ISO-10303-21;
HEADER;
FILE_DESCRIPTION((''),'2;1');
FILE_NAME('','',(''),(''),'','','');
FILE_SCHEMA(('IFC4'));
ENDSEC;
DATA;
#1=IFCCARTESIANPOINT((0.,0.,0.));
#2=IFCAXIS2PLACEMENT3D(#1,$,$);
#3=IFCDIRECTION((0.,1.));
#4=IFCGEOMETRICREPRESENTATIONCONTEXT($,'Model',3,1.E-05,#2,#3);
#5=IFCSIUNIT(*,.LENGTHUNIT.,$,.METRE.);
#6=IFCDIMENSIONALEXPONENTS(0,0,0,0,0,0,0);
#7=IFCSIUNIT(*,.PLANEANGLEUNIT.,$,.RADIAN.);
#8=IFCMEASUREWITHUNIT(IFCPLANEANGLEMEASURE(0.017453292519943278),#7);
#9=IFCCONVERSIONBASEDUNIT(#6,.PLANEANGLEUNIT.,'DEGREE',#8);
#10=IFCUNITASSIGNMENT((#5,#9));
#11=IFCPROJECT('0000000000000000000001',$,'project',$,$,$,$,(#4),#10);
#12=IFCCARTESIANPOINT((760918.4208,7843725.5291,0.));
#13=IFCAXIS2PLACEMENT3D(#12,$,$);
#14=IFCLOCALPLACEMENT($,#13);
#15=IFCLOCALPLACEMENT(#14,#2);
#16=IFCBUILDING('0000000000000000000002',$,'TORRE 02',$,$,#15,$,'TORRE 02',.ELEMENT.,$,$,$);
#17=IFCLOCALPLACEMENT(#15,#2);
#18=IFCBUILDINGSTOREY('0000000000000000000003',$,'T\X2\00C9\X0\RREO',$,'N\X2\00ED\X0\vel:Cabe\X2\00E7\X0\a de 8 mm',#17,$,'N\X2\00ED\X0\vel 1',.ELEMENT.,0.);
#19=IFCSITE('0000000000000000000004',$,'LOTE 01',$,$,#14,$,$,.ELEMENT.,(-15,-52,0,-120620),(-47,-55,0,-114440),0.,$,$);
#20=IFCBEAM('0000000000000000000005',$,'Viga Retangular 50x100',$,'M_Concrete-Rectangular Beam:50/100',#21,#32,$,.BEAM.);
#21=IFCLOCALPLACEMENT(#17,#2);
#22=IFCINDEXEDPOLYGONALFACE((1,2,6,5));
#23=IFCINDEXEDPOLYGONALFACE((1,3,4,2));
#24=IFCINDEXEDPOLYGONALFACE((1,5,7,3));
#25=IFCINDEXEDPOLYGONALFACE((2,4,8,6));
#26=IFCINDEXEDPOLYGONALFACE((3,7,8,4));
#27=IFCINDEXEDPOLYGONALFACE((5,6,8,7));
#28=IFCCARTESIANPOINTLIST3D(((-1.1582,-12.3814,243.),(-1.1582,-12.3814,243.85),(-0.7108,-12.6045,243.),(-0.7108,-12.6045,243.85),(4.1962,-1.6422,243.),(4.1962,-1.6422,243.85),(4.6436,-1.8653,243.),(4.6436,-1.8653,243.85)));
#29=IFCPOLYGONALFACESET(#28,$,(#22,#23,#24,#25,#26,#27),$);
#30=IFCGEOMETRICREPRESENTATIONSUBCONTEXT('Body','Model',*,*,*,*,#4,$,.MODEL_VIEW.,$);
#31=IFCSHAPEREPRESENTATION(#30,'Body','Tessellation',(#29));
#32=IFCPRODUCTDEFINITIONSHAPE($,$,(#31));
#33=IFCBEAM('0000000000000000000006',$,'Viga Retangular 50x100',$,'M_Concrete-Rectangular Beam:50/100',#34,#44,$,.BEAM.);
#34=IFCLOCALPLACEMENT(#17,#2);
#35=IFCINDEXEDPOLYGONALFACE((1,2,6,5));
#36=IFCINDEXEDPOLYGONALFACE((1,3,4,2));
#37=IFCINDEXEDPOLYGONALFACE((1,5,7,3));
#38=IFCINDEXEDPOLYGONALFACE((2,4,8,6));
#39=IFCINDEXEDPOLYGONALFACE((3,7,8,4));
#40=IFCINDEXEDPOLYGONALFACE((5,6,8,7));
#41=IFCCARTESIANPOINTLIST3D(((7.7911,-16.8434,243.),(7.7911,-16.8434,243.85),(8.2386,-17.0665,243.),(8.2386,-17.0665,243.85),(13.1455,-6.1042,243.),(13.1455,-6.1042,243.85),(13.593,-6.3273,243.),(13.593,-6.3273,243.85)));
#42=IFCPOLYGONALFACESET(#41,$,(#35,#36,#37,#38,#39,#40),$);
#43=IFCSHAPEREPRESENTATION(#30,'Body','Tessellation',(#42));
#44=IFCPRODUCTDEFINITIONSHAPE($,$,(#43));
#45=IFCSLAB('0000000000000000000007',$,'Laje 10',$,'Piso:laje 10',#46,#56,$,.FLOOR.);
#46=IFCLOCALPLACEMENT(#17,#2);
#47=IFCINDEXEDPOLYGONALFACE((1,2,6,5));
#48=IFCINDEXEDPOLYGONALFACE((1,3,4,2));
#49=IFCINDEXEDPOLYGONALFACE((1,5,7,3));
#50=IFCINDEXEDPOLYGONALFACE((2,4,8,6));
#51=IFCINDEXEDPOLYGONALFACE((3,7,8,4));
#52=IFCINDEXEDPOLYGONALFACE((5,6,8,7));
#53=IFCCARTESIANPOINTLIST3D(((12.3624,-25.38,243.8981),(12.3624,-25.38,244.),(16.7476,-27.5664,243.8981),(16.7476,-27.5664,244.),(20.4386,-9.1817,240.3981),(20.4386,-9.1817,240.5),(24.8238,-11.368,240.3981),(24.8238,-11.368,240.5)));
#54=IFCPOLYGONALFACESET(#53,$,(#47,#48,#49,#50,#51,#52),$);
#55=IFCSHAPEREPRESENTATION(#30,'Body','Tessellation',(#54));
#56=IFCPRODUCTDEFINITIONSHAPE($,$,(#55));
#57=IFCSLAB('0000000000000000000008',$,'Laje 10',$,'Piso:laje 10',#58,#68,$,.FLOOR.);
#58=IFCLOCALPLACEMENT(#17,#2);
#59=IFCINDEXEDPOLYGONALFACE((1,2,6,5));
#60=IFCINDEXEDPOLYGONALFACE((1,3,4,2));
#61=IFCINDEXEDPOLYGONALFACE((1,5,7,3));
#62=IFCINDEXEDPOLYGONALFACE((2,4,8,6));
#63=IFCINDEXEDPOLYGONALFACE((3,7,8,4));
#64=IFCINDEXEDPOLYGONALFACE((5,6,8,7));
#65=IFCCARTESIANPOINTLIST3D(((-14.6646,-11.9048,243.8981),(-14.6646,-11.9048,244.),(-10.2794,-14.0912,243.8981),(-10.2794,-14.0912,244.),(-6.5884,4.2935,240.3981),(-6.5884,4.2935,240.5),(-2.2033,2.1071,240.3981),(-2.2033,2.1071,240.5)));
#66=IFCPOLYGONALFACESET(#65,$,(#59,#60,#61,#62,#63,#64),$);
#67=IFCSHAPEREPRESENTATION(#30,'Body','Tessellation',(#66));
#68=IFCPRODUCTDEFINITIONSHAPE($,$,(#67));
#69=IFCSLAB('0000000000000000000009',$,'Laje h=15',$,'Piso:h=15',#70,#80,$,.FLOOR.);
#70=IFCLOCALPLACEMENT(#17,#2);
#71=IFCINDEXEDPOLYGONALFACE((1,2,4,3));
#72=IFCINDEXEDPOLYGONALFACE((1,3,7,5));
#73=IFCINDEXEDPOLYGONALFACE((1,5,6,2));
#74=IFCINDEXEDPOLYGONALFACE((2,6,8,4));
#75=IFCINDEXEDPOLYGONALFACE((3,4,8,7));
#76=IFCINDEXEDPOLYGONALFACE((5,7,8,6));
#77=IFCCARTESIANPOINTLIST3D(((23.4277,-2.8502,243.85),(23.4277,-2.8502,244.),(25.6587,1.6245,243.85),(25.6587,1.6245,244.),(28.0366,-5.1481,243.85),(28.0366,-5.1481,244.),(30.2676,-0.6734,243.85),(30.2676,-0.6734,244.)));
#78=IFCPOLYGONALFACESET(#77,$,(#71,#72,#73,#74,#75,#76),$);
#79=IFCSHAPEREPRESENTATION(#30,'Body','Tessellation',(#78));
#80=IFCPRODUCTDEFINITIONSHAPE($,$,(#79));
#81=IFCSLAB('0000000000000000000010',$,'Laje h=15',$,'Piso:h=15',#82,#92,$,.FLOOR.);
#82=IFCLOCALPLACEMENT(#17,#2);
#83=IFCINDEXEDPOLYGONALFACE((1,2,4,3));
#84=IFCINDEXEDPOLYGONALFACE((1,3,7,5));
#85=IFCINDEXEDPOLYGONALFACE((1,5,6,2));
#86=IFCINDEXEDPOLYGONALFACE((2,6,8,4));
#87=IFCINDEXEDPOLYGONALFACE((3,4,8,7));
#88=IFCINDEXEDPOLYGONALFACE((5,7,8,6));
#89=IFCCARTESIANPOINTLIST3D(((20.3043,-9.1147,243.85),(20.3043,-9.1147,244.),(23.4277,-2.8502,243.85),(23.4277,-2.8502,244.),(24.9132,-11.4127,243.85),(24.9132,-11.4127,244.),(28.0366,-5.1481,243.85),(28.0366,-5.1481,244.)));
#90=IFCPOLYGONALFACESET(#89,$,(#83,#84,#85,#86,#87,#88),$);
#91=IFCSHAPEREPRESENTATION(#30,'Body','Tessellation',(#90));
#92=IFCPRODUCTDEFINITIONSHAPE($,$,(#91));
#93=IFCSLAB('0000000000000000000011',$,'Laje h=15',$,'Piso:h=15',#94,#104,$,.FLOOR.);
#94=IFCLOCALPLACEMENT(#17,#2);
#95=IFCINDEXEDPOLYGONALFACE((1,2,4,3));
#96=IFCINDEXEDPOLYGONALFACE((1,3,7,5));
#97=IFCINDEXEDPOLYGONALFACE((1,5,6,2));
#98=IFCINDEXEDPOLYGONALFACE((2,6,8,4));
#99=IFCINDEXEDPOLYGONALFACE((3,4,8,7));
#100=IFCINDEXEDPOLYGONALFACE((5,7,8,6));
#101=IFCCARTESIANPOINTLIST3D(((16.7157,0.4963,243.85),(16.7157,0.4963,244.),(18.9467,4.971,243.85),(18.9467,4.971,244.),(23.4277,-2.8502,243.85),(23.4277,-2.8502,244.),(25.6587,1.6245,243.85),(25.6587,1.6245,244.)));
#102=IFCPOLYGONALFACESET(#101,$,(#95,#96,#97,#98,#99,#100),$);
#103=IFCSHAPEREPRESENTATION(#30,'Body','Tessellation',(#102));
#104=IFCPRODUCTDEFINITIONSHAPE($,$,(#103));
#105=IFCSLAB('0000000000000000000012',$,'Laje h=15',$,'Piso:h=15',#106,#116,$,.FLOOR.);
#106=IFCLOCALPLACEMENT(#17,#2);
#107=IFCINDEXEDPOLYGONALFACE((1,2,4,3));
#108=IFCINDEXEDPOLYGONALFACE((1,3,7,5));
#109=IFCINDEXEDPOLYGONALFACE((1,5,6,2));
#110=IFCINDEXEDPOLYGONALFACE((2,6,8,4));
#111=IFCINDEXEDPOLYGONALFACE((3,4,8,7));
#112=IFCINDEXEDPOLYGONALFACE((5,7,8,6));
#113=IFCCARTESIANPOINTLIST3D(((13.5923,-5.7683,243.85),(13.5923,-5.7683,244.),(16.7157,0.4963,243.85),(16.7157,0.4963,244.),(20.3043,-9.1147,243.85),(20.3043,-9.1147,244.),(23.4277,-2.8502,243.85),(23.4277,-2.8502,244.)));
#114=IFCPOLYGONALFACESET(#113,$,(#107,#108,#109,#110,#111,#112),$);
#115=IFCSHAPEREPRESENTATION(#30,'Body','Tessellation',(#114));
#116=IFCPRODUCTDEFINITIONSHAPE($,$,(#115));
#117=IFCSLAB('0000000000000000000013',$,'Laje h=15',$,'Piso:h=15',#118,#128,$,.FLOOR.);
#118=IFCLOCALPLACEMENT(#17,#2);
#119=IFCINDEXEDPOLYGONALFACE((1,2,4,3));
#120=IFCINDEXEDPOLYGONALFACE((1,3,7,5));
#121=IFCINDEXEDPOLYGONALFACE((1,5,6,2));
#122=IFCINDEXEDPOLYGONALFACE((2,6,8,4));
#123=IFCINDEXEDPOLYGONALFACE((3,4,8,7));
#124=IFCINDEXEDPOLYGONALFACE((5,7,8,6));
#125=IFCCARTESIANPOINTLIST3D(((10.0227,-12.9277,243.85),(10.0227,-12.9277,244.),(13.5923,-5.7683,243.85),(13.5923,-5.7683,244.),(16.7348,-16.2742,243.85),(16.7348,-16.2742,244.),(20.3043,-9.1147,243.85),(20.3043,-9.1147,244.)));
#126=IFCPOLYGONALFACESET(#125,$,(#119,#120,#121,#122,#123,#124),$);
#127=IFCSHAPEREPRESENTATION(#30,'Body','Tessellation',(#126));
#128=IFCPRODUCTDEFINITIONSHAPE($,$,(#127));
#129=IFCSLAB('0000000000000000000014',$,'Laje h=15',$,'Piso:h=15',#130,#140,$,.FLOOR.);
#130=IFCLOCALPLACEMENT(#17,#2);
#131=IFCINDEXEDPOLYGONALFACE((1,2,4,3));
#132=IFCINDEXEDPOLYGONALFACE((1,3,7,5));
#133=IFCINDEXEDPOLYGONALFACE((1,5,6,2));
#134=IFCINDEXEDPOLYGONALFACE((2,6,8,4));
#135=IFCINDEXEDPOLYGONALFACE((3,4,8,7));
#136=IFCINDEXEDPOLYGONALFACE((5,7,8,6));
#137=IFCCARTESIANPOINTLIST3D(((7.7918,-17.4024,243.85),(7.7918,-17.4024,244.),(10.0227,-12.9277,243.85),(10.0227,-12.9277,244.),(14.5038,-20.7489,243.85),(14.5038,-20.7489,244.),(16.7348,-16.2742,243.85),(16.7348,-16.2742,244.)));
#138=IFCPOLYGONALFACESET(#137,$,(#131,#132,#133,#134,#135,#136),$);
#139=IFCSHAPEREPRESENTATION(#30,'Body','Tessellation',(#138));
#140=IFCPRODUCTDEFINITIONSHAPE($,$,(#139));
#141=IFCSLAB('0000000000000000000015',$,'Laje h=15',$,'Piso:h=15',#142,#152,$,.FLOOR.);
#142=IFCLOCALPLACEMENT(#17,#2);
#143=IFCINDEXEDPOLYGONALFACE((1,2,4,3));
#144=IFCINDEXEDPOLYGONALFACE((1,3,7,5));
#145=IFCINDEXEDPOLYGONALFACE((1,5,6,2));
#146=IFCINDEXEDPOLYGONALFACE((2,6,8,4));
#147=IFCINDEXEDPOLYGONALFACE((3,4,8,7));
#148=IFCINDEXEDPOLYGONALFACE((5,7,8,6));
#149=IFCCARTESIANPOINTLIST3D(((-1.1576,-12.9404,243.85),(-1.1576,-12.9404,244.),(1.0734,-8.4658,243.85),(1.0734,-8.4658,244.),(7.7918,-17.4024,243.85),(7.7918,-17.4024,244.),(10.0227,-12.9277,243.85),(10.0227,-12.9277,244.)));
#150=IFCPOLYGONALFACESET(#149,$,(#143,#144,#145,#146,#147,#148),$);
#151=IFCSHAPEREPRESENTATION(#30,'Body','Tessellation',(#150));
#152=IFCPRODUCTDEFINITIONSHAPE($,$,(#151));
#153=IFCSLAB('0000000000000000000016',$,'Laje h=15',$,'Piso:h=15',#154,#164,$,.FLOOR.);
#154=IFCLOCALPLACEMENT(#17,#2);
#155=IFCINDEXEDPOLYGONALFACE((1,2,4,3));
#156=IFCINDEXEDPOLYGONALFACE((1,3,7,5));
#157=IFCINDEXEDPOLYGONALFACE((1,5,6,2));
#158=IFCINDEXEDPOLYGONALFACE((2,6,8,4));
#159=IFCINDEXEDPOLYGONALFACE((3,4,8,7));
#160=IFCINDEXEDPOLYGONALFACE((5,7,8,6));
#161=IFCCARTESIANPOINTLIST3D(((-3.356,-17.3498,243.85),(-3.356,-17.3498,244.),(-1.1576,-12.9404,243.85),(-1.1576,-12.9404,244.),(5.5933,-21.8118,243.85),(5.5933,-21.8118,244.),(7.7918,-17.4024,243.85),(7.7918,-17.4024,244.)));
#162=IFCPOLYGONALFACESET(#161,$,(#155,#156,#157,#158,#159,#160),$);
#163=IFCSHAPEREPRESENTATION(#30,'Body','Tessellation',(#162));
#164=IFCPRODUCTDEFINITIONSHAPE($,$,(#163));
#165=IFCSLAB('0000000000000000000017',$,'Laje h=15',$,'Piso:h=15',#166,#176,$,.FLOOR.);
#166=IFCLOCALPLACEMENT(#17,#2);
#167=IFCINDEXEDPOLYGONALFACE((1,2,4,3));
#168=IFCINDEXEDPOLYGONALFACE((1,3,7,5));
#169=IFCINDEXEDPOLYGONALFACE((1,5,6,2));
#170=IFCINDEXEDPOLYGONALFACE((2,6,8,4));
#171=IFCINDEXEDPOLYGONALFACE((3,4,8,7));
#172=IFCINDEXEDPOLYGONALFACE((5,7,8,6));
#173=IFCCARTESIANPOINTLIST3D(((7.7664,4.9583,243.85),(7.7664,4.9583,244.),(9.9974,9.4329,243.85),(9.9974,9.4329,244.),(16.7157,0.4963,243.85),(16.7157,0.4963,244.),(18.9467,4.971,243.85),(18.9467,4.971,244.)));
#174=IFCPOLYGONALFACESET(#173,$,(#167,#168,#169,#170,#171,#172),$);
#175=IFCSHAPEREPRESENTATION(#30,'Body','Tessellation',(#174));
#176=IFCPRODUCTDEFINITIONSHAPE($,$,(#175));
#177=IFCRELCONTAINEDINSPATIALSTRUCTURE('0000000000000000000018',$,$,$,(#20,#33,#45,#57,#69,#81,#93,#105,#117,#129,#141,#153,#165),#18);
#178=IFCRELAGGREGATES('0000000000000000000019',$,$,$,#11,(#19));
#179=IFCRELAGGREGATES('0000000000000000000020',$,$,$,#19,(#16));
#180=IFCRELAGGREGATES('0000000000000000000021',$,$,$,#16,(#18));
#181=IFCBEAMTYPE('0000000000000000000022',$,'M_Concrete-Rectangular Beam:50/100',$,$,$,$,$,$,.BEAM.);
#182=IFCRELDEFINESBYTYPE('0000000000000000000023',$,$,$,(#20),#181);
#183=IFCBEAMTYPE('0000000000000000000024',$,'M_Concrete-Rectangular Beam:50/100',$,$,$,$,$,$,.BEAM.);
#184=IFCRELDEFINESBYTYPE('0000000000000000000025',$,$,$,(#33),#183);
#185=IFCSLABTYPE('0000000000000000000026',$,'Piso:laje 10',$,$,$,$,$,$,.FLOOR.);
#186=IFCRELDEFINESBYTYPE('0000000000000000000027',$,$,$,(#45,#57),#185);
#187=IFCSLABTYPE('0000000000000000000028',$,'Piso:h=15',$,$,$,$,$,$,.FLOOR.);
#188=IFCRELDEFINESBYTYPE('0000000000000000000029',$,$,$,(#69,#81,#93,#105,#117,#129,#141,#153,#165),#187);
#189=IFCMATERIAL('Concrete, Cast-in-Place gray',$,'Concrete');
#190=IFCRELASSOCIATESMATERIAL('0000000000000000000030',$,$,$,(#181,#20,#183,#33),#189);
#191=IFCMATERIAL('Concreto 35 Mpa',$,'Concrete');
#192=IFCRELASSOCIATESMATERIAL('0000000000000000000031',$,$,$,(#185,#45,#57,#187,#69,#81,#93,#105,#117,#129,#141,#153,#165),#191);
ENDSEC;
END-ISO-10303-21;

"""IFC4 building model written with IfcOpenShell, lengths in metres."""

from ifc_helpers import new_model, entity, si_unit, converted_unit, direction, frame, frame_2d, origin, place, context, subcontext, project, spatial, indexed_curve, rectangle, outline, extrude, source, transform, mapped, material, type_object, type_shapes, element, save


model = new_model("IFC4")

# Units and contexts
model_context = context("Model", 3, precision=1e-05, world=origin(), true_north=direction((0.0, 1.0)))
body_context = subcontext(model_context, "Body", "Model", "MODEL_VIEW")
ifc_project = project(units=[si_unit("LENGTHUNIT", "METRE"), converted_unit("PLANEANGLEUNIT", "DEGREE", entity("IfcPlaneAngleMeasure", 0.017453292519943278), si_unit("PLANEANGLEUNIT", "RADIAN"), dimensions=[0, 0, 0, 0, 0, 0, 0])], contexts=[model_context])

# Site, building, storey
site_placement = place(None, frame((760918.4208, 7843725.5291, 0.0)))
site = spatial("IfcSite", under=ifc_project, at=site_placement, Name="LOTE 01", CompositionType="ELEMENT", RefLatitude=(-15, -52, 0, -120620), RefLongitude=(-47, -55, 0, -114440), RefElevation=0.0)
building_placement = place(site_placement, origin())
building = spatial("IfcBuilding", under=site, at=building_placement, Name="TORRE 02", LongName="TORRE 02", CompositionType="ELEMENT")
storey_placement = place(building_placement, origin())
storey = spatial("IfcBuildingStorey", under=building, at=storey_placement, Name="TÉRREO", ObjectType="Nível:Cabeça de 8 mm", LongName="Nível 1", CompositionType="ELEMENT", Elevation=0.0)

# Shared definitions
ifc_material_1 = material(Name="Concrete, Cast-in-Place gray", Category="Concrete")
placement = place(building_placement, frame((0.0, 0.0, 244.0)))

# Beams
beam_type_1 = type_object("IfcBeamType", Name="M_Concrete-Rectangular Beam:50/100", PredefinedType="BEAM", material=ifc_material_1)
shared_shape_1 = source(origin(), body_context, "Body", "SweptSolid", [
    extrude(outline(indexed_curve([(-0.425, -0.25), (0.425, -0.25), (0.425, 0.25), (-0.425, 0.25), (-0.425, -0.25)], self_intersect=False)), frame((-0.9345, -12.493, 243.425), z_axis=(0.446198, 0.894934, 0.0), x_axis=(0.0, 0.0, 1.0)), (0.0, 0.0, 1.0), 12.0),
])
type_shapes(beam_type_1, [shared_shape_1])
beam_1_placement = place(placement, frame((0.0, 0.0, -244.0)))
element("IfcBeam", 1, at=beam_1_placement, inside=storey, type_object=beam_type_1, material=ifc_material_1, Name="Viga Retangular 50x100", ObjectType="M_Concrete-Rectangular Beam:50/100", PredefinedType="BEAM", context=body_context, shape_type="MappedRepresentation", body=[
    mapped(shared_shape_1, transform((0.0, 0.0, 0.0), scale=1.0)),
])
beam_type_2 = type_object("IfcBeamType", Name="M_Concrete-Rectangular Beam:50/100", PredefinedType="BEAM", material=ifc_material_1)
shared_shape_2 = source(origin(), body_context, "Body", "SweptSolid", [
    extrude(outline(indexed_curve([(-0.425, -0.25), (0.425, -0.25), (0.425, 0.25), (-0.425, 0.25), (-0.425, -0.25)], self_intersect=False)), frame((8.0149, -16.9549, 243.425), z_axis=(0.446198, 0.894934, 0.0), x_axis=(0.0, 0.0, 1.0)), (0.0, 0.0, 1.0), 12.0),
])
type_shapes(beam_type_2, [shared_shape_2])
beam_2_placement = place(placement, frame((0.0, 0.0, -244.0)))
element("IfcBeam", 2, at=beam_2_placement, inside=storey, type_object=beam_type_2, material=ifc_material_1, Name="Viga Retangular 50x100", ObjectType="M_Concrete-Rectangular Beam:50/100", PredefinedType="BEAM", context=body_context, shape_type="MappedRepresentation", body=[
    mapped(shared_shape_2, transform((0.0, 0.0, 0.0), scale=1.0)),
])

# Slabs
ifc_material_2 = material(Name="Concreto 35 Mpa", Category="Concrete")
slab_type_1 = type_object("IfcSlabType", Name="Piso:laje 10", PredefinedType="FLOOR", material=ifc_material_2)
slab_1_placement = place(placement, frame((12.3624, -27.5664, -3.6019)))
element("IfcSlab", 3, at=slab_1_placement, inside=storey, type_object=slab_type_1, material=ifc_material_2, Name="Laje 10", ObjectType="Piso:laje 10", PredefinedType="FLOOR", context=body_context, shape_type="SweptSolid", body=[
    extrude(rectangle(XDim=4.9, YDim=18.4353, at=frame_2d((6.2532, 7.2018), x_axis=(-0.898163, 0.439663))), frame((0.0, 2.1864, 3.6019), z_axis=(0.084712, 0.169906, 0.981812), x_axis=(0.996405, -0.014445, -0.083471)), (0.083471, 0.170519, -0.981812), 0.1019),
])
slab_2_placement = place(placement, frame((-14.6646, -14.0912, -3.6019)))
element("IfcSlab", 4, at=slab_2_placement, inside=storey, type_object=slab_type_1, material=ifc_material_2, Name="Laje 10", ObjectType="Piso:laje 10", PredefinedType="FLOOR", context=body_context, shape_type="SweptSolid", body=[
    extrude(rectangle(XDim=4.9, YDim=18.4353, at=frame_2d((6.2532, 7.2018), x_axis=(-0.898163, 0.439663))), frame((0.0, 2.1864, 3.6019), z_axis=(0.084712, 0.169906, 0.981812), x_axis=(0.996405, -0.014445, -0.083471)), (0.083471, 0.170519, -0.981812), 0.1019),
])
slab_type_2 = type_object("IfcSlabType", Name="Piso:h=15", PredefinedType="FLOOR", material=ifc_material_2)
slab_3_placement = place(placement, origin())
element("IfcSlab", 5, at=slab_3_placement, inside=storey, type_object=slab_type_2, material=ifc_material_2, Name="Laje h=15", ObjectType="Piso:h=15", PredefinedType="FLOOR", context=body_context, shape_type="SweptSolid", body=[
    extrude(outline(indexed_curve([(-2.5, -2.575), (2.5, -2.575), (2.5, 2.575), (-2.5, 2.575), (-2.5, -2.575)], self_intersect=False)), frame((26.8477, -1.7618, 0.0), z_axis=(0.0, 0.0, -1.0), x_axis=(-0.446198, -0.894934, 0.0)), (0.0, 0.0, 1.0), 0.15),
])
slab_4_placement = place(placement, origin())
element("IfcSlab", 6, at=slab_4_placement, inside=storey, type_object=slab_type_2, material=ifc_material_2, Name="Laje h=15", ObjectType="Piso:h=15", PredefinedType="FLOOR", context=body_context, shape_type="SweptSolid", body=[
    extrude(outline(indexed_curve([(-3.5, -2.575), (3.5, -2.575), (3.5, 2.575), (-3.5, 2.575), (-3.5, -2.575)], self_intersect=False)), frame((24.1705, -7.1314, 0.0), z_axis=(0.0, 0.0, -1.0), x_axis=(-0.446198, -0.894934, 0.0)), (0.0, 0.0, 1.0), 0.15),
])
slab_5_placement = place(placement, origin())
element("IfcSlab", 7, at=slab_5_placement, inside=storey, type_object=slab_type_2, material=ifc_material_2, Name="Laje h=15", ObjectType="Piso:h=15", PredefinedType="FLOOR", context=body_context, shape_type="SweptSolid", body=[
    extrude(outline(indexed_curve([(-3.75, -2.5), (3.75, -2.5), (3.75, 2.5), (-3.75, 2.5), (-3.75, -2.5)], self_intersect=False)), frame((21.1872, 1.0604, 0.0), z_axis=(0.0, 0.0, -1.0), x_axis=(0.894934, -0.446198, 0.0)), (0.0, 0.0, 1.0), 0.15),
])
slab_6_placement = place(placement, origin())
element("IfcSlab", 8, at=slab_6_placement, inside=storey, type_object=slab_type_2, material=ifc_material_2, Name="Laje h=15", ObjectType="Piso:h=15", PredefinedType="FLOOR", context=body_context, shape_type="SweptSolid", body=[
    extrude(outline(indexed_curve([(-3.5, -3.75), (3.5, -3.75), (3.5, 3.75), (-3.5, 3.75), (-3.5, -3.75)], self_intersect=False)), frame((18.51, -4.3092, 0.0), z_axis=(0.0, 0.0, -1.0), x_axis=(-0.446198, -0.894934, 0.0)), (0.0, 0.0, 1.0), 0.15),
])
slab_7_placement = place(placement, origin())
element("IfcSlab", 9, at=slab_7_placement, inside=storey, type_object=slab_type_2, material=ifc_material_2, Name="Laje h=15", ObjectType="Piso:h=15", PredefinedType="FLOOR", context=body_context, shape_type="SweptSolid", body=[
    extrude(outline(indexed_curve([(-4.0, -3.75), (4.0, -3.75), (4.0, 3.75), (-4.0, 3.75), (-4.0, -3.75)], self_intersect=False)), frame((15.1635, -11.0212, 0.0), z_axis=(0.0, 0.0, -1.0), x_axis=(-0.446198, -0.894934, 0.0)), (0.0, 0.0, 1.0), 0.15),
])
slab_8_placement = place(placement, origin())
element("IfcSlab", 10, at=slab_8_placement, inside=storey, type_object=slab_type_2, material=ifc_material_2, Name="Laje h=15", ObjectType="Piso:h=15", PredefinedType="FLOOR", context=body_context, shape_type="SweptSolid", body=[
    extrude(outline(indexed_curve([(-2.5, -3.75), (2.5, -3.75), (2.5, 3.75), (-2.5, 3.75), (-2.5, -3.75)], self_intersect=False)), frame((12.2633, -16.8383, 0.0), z_axis=(0.0, 0.0, -1.0), x_axis=(-0.446198, -0.894934, 0.0)), (0.0, 0.0, 1.0), 0.15),
])
slab_9_placement = place(placement, origin())
element("IfcSlab", 11, at=slab_9_placement, inside=storey, type_object=slab_type_2, material=ifc_material_2, Name="Laje h=15", ObjectType="Piso:h=15", PredefinedType="FLOOR", context=body_context, shape_type="SweptSolid", body=[
    extrude(outline(indexed_curve([(-2.5, -5.0), (2.5, -5.0), (2.5, 5.0), (-2.5, 5.0), (-2.5, -5.0)], self_intersect=False)), frame((4.4326, -12.9341, 0.0), z_axis=(0.0, 0.0, -1.0), x_axis=(-0.446198, -0.894934, 0.0)), (0.0, 0.0, 1.0), 0.15),
])
slab_10_placement = place(placement, origin())
element("IfcSlab", 12, at=slab_10_placement, inside=storey, type_object=slab_type_2, material=ifc_material_2, Name="Laje h=15", ObjectType="Piso:h=15", PredefinedType="FLOOR", context=body_context, shape_type="SweptSolid", body=[
    extrude(outline(indexed_curve([(-2.4635, -5.0), (2.4635, -5.0), (2.4635, 5.0), (-2.4635, 5.0), (-2.4635, -5.0)], self_intersect=False)), frame((2.2179, -17.3761, 0.0), z_axis=(0.0, 0.0, -1.0), x_axis=(-0.446198, -0.894934, 0.0)), (0.0, 0.0, 1.0), 0.15),
])
slab_11_placement = place(placement, origin())
element("IfcSlab", 13, at=slab_11_placement, inside=storey, type_object=slab_type_2, material=ifc_material_2, Name="Laje h=15", ObjectType="Piso:h=15", PredefinedType="FLOOR", context=body_context, shape_type="SweptSolid", body=[
    extrude(outline(indexed_curve([(-2.5, -5.0), (2.5, -5.0), (2.5, 5.0), (-2.5, 5.0), (-2.5, -5.0)], self_intersect=False)), frame((13.3565, 4.9646, 0.0), z_axis=(0.0, 0.0, -1.0), x_axis=(-0.446198, -0.894934, 0.0)), (0.0, 0.0, 1.0), 0.15),
])

save(model, "model.ifc")
